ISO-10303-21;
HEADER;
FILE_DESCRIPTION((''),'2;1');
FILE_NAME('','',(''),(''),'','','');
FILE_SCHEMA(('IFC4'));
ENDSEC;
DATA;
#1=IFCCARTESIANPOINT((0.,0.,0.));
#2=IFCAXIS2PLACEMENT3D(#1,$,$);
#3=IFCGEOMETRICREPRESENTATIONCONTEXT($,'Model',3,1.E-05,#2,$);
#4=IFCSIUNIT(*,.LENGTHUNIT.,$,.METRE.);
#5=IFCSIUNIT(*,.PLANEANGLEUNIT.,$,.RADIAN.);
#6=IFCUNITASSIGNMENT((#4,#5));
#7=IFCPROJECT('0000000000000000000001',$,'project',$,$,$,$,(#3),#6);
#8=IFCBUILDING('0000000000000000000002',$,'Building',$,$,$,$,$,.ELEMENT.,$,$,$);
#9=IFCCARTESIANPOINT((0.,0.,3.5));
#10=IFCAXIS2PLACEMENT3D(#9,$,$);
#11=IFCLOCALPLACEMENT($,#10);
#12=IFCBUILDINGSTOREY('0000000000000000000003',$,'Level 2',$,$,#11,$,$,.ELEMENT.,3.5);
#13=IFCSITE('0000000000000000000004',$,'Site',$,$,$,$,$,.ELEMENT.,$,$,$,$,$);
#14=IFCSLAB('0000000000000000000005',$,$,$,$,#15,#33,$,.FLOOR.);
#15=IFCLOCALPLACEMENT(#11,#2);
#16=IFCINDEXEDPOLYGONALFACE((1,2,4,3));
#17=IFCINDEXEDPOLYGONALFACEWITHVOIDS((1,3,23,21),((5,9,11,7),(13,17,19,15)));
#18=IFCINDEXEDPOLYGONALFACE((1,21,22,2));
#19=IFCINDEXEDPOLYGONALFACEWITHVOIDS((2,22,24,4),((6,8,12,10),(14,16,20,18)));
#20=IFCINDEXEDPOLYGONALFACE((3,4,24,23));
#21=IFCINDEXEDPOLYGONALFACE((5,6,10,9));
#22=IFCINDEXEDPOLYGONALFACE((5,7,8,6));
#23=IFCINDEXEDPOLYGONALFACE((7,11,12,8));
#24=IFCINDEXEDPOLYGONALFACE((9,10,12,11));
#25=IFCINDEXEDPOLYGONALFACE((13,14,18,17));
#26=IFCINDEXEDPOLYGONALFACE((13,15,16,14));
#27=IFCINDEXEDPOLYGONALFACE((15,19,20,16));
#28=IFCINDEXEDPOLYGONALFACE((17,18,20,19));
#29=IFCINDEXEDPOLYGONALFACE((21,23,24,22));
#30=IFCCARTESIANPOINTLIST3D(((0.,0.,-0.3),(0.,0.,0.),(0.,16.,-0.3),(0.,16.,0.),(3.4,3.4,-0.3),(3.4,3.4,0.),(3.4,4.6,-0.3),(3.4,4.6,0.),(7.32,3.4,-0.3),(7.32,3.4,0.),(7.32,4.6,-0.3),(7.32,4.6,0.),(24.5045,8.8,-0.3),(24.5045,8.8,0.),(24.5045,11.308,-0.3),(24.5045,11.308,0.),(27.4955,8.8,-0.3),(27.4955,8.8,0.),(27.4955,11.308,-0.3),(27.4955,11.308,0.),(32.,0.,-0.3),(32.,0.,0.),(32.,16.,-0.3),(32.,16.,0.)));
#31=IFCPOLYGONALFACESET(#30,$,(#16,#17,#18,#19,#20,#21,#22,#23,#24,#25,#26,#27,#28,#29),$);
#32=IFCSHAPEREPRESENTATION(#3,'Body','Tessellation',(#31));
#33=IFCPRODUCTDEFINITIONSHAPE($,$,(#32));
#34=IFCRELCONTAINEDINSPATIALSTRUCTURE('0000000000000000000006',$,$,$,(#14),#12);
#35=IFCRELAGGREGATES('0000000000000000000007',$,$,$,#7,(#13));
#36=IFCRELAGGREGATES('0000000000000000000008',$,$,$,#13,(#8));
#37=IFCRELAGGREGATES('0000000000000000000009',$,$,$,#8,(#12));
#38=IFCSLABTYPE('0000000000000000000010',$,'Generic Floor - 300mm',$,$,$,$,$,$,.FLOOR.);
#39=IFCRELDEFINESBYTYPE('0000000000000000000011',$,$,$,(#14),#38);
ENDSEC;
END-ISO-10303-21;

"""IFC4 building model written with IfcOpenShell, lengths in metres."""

from ifc_helpers import new_model, si_unit, frame, origin, place, context, project, spatial, polyline, outline, extrude, type_object, element, save


model = new_model("IFC4")

# Units and contexts
model_context = context("Model", 3, precision=1e-05, world=origin())
ifc_project = project(units=[si_unit("LENGTHUNIT", "METRE"), si_unit("PLANEANGLEUNIT", "RADIAN")], contexts=[model_context])

# Site, building, storey
site = spatial("IfcSite", under=ifc_project, Name="Site", CompositionType="ELEMENT")
building = spatial("IfcBuilding", under=site, Name="Building", CompositionType="ELEMENT")
storey_placement = place(None, frame((0.0, 0.0, 3.5)))
storey = spatial("IfcBuildingStorey", under=building, at=storey_placement, Name="Level 2", CompositionType="ELEMENT", Elevation=3.5)

# Slab, openings
slab_type = type_object("IfcSlabType", Name="Generic Floor - 300mm", PredefinedType="FLOOR")
slab_placement = place(None, frame((0.0, 0.0, 3.5)))
slab = element("IfcSlab", 1, at=slab_placement, inside=storey, type_object=slab_type, PredefinedType="FLOOR", context=model_context, shape_type="SweptSolid", body=[
    extrude(outline(polyline([(0.0, 0.0), (32.0, 0.0), (32.0, 16.0), (0.0, 16.0), (0.0, 0.0)])), origin(), (0.0, 0.0, -1.0), 0.3),
])
opening_1_placement = place(None, frame((0.0, 0.0, 3.501)))
element("IfcOpeningElement", 2, at=opening_1_placement, cuts=slab, PredefinedType="OPENING", context=model_context, shape_type="SweptSolid", body=[
    extrude(outline(polyline([(3.4, 4.6), (3.4, 3.4), (7.32, 3.4), (7.32, 4.6), (3.4, 4.6)])), origin(), (0.0, 0.0, -1.0), 0.302),
])
opening_2_placement = place(None, frame((0.0, 0.0, 3.501)))
element("IfcOpeningElement", 3, at=opening_2_placement, cuts=slab, PredefinedType="OPENING", context=model_context, shape_type="SweptSolid", body=[
    extrude(outline(polyline([(24.5045, 8.8), (27.4955, 8.8), (27.4955, 11.308), (24.5045, 11.308), (24.5045, 8.8)])), origin(), (0.0, 0.0, -1.0), 0.302),
])

save(model, "model.ifc")
